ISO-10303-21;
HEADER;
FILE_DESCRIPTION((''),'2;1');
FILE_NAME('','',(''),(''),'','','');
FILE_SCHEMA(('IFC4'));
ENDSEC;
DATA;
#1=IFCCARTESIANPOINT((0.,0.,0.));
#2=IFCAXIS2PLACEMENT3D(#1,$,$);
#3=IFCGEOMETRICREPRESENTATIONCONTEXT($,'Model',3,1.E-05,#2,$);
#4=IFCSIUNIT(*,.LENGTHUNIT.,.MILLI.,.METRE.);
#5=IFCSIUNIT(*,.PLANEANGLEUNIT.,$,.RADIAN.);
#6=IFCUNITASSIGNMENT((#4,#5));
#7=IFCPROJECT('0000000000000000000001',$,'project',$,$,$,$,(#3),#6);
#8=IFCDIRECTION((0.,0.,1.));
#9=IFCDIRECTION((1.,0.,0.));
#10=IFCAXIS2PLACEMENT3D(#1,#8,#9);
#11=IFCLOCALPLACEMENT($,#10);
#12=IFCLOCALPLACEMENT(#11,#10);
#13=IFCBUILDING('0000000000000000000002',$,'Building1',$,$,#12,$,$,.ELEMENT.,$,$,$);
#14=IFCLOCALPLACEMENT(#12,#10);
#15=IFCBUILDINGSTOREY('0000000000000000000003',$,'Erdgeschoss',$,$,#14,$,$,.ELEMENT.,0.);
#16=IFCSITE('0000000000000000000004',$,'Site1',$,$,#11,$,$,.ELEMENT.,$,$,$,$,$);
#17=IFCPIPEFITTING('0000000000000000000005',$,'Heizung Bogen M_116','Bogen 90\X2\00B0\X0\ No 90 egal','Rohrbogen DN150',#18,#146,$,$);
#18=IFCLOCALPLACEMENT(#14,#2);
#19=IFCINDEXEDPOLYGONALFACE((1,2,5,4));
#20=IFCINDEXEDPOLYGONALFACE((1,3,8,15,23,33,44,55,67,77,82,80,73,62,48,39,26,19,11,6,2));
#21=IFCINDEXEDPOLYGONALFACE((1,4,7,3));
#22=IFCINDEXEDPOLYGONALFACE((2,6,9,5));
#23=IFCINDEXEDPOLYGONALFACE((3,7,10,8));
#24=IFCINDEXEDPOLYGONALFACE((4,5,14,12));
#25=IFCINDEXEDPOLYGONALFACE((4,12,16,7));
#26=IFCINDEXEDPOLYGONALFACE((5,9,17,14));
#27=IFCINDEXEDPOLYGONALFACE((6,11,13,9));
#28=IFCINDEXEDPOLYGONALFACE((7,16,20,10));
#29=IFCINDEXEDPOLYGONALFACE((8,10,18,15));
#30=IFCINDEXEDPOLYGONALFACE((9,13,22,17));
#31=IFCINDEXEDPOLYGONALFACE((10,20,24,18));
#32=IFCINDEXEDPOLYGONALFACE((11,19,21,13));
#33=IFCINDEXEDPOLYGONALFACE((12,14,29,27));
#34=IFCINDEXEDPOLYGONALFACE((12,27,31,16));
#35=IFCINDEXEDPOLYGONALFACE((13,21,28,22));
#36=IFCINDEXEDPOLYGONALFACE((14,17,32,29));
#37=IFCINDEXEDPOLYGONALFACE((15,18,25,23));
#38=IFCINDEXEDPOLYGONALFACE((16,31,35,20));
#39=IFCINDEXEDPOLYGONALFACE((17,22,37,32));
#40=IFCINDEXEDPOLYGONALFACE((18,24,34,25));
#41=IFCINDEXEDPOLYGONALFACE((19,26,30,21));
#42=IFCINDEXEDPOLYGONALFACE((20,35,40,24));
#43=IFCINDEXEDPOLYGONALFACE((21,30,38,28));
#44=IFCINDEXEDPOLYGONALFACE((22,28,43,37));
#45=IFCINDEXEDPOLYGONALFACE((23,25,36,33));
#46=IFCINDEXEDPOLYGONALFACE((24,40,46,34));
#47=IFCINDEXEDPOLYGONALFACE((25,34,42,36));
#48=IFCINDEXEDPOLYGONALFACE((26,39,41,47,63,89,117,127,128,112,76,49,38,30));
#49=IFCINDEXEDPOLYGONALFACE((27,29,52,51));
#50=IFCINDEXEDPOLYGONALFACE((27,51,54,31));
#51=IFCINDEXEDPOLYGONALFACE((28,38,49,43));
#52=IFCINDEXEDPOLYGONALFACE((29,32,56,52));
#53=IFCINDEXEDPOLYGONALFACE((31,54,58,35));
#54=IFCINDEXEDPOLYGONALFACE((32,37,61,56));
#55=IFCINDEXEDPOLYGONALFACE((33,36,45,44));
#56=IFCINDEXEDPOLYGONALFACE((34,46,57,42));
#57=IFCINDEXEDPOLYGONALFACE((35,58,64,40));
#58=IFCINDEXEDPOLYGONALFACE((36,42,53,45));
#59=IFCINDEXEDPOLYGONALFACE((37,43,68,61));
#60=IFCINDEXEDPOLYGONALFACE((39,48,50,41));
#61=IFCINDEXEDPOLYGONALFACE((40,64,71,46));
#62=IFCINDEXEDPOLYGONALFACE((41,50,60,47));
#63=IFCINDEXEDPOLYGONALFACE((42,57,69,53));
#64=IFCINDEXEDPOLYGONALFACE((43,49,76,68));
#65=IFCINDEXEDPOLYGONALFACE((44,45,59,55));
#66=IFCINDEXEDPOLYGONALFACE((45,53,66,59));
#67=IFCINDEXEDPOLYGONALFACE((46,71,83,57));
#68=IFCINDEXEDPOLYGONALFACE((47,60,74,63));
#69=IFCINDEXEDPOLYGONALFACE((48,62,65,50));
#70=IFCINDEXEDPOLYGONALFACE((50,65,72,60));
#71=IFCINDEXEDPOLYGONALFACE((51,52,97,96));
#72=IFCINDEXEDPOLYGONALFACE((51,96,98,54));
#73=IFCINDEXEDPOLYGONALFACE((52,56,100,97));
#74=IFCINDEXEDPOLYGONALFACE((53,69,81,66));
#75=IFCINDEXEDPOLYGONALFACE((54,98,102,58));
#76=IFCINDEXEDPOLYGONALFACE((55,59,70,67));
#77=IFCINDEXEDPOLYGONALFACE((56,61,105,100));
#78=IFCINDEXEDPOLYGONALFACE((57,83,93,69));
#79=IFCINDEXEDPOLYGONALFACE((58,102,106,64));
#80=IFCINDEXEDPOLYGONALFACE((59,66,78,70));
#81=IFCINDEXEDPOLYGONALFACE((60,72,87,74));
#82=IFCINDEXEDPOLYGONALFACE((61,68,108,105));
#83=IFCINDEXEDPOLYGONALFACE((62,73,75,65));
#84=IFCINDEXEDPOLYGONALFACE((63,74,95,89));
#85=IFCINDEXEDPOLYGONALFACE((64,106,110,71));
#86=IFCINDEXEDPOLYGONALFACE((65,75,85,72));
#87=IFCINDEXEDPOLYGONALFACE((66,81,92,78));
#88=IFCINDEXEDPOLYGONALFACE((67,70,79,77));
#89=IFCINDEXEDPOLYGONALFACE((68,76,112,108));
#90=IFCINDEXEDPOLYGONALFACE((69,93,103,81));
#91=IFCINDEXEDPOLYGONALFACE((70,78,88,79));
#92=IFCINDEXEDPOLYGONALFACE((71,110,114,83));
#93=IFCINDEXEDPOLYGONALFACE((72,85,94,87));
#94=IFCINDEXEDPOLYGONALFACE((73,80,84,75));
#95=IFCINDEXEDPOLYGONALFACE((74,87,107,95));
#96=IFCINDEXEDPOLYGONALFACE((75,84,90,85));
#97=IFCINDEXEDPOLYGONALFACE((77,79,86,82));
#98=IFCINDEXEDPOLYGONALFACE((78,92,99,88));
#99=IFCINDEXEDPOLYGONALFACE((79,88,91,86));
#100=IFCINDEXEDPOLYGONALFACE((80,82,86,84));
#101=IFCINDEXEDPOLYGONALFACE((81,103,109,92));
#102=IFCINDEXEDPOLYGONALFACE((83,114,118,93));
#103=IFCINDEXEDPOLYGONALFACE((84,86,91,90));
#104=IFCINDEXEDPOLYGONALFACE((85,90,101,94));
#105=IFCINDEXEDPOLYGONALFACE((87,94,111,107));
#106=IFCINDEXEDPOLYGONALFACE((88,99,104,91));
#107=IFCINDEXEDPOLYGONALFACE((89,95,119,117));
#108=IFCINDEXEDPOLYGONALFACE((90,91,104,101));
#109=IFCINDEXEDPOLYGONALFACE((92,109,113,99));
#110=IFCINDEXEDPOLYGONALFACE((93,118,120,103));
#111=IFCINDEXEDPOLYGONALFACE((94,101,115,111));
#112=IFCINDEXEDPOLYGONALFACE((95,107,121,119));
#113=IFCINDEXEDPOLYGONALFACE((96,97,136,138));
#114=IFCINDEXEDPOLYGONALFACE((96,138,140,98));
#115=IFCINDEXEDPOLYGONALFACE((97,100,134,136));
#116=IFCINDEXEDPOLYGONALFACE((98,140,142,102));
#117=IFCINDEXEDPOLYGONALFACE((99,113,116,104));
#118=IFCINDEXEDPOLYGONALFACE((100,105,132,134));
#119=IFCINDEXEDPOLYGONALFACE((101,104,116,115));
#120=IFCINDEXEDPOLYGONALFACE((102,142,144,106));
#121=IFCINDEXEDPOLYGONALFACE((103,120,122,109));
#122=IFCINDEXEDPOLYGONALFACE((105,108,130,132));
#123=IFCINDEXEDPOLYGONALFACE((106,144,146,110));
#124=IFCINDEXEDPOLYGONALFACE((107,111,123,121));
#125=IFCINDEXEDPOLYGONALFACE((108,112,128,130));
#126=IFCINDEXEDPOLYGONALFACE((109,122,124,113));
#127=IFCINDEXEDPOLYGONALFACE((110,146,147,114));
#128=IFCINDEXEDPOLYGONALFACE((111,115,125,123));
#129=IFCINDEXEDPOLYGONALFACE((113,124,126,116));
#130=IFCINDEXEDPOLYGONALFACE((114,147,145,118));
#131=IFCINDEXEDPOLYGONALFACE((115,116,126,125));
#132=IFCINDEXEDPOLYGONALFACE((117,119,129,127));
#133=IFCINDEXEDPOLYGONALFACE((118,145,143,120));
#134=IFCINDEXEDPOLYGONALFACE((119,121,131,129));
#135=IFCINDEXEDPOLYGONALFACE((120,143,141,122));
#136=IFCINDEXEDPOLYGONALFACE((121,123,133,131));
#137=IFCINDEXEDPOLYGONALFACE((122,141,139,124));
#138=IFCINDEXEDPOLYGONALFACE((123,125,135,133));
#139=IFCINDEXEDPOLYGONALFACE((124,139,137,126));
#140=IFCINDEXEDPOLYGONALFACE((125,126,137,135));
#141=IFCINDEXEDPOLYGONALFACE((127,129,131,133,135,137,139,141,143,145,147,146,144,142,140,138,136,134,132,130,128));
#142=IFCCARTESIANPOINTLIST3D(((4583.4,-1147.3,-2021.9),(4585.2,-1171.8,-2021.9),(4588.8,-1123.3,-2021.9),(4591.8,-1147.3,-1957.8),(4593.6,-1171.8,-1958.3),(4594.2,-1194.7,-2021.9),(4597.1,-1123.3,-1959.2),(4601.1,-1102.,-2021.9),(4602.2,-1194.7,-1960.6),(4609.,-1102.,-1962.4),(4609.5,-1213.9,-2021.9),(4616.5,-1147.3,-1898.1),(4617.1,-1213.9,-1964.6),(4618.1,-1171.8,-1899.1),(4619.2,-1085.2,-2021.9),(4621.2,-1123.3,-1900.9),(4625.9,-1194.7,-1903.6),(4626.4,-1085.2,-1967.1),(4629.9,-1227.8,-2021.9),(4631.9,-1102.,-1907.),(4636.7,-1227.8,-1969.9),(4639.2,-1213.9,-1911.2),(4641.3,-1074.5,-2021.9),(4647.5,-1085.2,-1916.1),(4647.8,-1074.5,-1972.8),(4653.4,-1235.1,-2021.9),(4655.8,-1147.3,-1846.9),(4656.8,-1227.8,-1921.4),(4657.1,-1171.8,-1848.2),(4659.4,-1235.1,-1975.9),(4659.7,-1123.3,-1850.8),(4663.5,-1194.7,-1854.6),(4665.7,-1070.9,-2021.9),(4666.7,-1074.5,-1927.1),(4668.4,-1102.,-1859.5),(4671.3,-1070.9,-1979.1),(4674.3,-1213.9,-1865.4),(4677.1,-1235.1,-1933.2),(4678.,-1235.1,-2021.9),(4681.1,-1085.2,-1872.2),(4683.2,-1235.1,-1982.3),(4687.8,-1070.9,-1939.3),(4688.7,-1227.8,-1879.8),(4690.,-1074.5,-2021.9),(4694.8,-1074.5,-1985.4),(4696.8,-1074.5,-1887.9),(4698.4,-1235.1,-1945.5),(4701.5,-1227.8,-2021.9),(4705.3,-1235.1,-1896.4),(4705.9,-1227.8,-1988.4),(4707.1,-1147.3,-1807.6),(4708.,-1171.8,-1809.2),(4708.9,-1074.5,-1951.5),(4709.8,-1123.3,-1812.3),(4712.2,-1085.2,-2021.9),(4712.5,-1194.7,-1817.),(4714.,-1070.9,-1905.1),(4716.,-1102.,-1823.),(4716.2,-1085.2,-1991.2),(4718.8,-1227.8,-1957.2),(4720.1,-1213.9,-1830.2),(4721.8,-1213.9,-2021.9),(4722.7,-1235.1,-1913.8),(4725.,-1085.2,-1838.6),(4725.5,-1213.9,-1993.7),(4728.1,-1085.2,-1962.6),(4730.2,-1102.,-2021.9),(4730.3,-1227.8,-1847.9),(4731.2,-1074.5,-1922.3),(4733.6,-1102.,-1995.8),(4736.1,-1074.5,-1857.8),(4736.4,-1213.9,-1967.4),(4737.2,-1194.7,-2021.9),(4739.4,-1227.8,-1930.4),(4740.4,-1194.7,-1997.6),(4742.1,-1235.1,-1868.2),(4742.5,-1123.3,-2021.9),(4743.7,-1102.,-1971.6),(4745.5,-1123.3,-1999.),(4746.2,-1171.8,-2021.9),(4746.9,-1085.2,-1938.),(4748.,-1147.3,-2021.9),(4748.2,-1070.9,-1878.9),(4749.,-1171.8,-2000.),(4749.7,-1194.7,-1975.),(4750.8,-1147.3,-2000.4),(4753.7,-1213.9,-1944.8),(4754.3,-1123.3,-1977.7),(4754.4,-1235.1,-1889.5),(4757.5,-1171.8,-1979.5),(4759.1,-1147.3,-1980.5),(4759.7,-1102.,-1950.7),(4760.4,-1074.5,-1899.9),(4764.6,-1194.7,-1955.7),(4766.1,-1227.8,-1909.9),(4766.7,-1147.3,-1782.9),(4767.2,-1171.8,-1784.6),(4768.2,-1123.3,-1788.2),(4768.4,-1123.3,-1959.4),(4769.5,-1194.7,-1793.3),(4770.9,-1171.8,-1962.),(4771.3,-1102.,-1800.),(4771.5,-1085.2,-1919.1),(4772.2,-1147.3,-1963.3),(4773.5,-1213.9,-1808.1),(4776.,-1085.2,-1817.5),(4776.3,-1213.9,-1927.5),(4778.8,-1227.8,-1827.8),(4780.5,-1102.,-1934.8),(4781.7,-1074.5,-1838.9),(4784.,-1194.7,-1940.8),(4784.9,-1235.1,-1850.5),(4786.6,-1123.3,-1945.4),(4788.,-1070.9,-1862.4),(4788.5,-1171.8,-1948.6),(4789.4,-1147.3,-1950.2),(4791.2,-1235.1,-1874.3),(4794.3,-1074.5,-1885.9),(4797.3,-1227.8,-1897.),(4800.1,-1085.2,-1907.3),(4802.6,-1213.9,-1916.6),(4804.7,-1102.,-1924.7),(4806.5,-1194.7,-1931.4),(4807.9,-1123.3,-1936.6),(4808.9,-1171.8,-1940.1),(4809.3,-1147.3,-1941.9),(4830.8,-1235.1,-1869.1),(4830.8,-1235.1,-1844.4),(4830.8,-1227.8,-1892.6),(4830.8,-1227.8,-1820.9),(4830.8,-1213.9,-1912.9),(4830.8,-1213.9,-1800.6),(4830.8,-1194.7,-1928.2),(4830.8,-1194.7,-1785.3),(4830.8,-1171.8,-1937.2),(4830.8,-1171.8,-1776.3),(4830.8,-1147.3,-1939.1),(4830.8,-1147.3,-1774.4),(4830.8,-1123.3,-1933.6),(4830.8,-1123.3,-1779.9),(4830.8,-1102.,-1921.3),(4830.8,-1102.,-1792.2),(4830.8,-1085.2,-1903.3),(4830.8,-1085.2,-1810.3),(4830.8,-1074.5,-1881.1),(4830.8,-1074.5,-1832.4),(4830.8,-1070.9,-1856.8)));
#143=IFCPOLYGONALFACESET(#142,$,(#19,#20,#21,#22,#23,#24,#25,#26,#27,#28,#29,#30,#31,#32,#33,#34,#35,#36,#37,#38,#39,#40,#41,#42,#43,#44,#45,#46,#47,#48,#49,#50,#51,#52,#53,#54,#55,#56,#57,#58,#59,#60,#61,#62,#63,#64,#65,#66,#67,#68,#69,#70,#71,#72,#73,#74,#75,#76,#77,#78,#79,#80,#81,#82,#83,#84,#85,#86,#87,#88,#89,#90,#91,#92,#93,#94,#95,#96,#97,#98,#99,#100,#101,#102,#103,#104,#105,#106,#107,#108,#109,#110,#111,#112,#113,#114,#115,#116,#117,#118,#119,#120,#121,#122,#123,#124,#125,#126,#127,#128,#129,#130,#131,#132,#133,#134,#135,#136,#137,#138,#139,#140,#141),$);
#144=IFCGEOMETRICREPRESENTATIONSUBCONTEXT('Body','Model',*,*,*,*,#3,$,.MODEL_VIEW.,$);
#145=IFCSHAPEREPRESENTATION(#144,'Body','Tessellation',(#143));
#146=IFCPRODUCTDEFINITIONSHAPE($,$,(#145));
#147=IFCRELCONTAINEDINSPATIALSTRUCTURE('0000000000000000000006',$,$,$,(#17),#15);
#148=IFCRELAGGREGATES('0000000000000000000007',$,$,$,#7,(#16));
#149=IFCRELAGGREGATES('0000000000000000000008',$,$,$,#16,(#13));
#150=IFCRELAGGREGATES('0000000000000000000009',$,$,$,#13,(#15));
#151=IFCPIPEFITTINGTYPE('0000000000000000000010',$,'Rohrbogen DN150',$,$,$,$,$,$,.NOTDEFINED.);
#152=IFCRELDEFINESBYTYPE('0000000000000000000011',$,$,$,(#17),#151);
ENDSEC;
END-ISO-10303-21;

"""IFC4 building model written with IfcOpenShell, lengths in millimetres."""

from ifc_helpers import new_model, entity, si_unit, frame, origin, origin_with_axes, place, context, subcontext, project, spatial, source, transform, mapped, type_object, element, save


model = new_model("IFC4")

# Units and contexts
model_context = context("Model", 3, precision=1e-05, world=origin())
body_context = subcontext(model_context, "Body", "Model", "MODEL_VIEW")
ifc_project = project(units=[si_unit("LENGTHUNIT", "METRE", prefix="MILLI"), si_unit("PLANEANGLEUNIT", "RADIAN")], contexts=[model_context])

# Site, building, storey
site_placement = place(None, origin_with_axes())
site = spatial("IfcSite", under=ifc_project, at=site_placement, Name="Site1", CompositionType="ELEMENT")
building_placement = place(site_placement, origin_with_axes())
building = spatial("IfcBuilding", under=site, at=building_placement, Name="Building1", CompositionType="ELEMENT")
storey_placement = place(building_placement, origin_with_axes())
storey = spatial("IfcBuildingStorey", under=building, at=storey_placement, Name="Erdgeschoss", CompositionType="ELEMENT", Elevation=0.0)

# Pipe fitting
pipe_fitting_type_1 = type_object("IfcPipeFittingType", Name="Rohrbogen DN150", PredefinedType="NOTDEFINED")
shared_shape_1 = source(origin_with_axes(), body_context, "Body", "SolidModel", [
    entity("IfcRevolvedAreaSolid", entity("IfcCircleProfileDef", "AREA", None, entity("IfcAxis2Placement2D", entity("IfcCartesianPoint", [0.0, 0.0]), entity("IfcDirection", [1.0, 0.0])), 82.5), entity("IfcAxis2Placement3D", entity("IfcCartesianPoint", [123.8, 41.3, 0.0]), entity("IfcDirection", [-1.0, 0.0, 0.0]), entity("IfcDirection", [0.0, 0.0, -1.0])), entity("IfcAxis1Placement", entity("IfcCartesianPoint", [0.0, 165.1, 0.0]), entity("IfcDirection", [-1.0, 0.0, 0.0])), 1.570796),
])
pipe_fitting_1_placement = place(storey_placement, frame((4706.9, -1153.4, -1898.0), z_axis=(0.0, 0.0, 1.0), x_axis=(1.0, 0.0, 0.0)))
element("IfcPipeFitting", 1, at=pipe_fitting_1_placement, inside=storey, type_object=pipe_fitting_type_1, Name="Heizung Bogen M_116", Description="Bogen 90° No 90 egal", ObjectType="Rohrbogen DN150", context=body_context, shape_type="MappedRepresentation", body=[
    mapped(shared_shape_1, transform((0.0, 0.0, 0.0), x_axis=(1.0, 0.0, 0.0), y_axis=(0.0, 0.0, 1.0), z_axis=(0.0, -1.0, 0.0), scale=1.0)),
])

save(model, "model.ifc")
